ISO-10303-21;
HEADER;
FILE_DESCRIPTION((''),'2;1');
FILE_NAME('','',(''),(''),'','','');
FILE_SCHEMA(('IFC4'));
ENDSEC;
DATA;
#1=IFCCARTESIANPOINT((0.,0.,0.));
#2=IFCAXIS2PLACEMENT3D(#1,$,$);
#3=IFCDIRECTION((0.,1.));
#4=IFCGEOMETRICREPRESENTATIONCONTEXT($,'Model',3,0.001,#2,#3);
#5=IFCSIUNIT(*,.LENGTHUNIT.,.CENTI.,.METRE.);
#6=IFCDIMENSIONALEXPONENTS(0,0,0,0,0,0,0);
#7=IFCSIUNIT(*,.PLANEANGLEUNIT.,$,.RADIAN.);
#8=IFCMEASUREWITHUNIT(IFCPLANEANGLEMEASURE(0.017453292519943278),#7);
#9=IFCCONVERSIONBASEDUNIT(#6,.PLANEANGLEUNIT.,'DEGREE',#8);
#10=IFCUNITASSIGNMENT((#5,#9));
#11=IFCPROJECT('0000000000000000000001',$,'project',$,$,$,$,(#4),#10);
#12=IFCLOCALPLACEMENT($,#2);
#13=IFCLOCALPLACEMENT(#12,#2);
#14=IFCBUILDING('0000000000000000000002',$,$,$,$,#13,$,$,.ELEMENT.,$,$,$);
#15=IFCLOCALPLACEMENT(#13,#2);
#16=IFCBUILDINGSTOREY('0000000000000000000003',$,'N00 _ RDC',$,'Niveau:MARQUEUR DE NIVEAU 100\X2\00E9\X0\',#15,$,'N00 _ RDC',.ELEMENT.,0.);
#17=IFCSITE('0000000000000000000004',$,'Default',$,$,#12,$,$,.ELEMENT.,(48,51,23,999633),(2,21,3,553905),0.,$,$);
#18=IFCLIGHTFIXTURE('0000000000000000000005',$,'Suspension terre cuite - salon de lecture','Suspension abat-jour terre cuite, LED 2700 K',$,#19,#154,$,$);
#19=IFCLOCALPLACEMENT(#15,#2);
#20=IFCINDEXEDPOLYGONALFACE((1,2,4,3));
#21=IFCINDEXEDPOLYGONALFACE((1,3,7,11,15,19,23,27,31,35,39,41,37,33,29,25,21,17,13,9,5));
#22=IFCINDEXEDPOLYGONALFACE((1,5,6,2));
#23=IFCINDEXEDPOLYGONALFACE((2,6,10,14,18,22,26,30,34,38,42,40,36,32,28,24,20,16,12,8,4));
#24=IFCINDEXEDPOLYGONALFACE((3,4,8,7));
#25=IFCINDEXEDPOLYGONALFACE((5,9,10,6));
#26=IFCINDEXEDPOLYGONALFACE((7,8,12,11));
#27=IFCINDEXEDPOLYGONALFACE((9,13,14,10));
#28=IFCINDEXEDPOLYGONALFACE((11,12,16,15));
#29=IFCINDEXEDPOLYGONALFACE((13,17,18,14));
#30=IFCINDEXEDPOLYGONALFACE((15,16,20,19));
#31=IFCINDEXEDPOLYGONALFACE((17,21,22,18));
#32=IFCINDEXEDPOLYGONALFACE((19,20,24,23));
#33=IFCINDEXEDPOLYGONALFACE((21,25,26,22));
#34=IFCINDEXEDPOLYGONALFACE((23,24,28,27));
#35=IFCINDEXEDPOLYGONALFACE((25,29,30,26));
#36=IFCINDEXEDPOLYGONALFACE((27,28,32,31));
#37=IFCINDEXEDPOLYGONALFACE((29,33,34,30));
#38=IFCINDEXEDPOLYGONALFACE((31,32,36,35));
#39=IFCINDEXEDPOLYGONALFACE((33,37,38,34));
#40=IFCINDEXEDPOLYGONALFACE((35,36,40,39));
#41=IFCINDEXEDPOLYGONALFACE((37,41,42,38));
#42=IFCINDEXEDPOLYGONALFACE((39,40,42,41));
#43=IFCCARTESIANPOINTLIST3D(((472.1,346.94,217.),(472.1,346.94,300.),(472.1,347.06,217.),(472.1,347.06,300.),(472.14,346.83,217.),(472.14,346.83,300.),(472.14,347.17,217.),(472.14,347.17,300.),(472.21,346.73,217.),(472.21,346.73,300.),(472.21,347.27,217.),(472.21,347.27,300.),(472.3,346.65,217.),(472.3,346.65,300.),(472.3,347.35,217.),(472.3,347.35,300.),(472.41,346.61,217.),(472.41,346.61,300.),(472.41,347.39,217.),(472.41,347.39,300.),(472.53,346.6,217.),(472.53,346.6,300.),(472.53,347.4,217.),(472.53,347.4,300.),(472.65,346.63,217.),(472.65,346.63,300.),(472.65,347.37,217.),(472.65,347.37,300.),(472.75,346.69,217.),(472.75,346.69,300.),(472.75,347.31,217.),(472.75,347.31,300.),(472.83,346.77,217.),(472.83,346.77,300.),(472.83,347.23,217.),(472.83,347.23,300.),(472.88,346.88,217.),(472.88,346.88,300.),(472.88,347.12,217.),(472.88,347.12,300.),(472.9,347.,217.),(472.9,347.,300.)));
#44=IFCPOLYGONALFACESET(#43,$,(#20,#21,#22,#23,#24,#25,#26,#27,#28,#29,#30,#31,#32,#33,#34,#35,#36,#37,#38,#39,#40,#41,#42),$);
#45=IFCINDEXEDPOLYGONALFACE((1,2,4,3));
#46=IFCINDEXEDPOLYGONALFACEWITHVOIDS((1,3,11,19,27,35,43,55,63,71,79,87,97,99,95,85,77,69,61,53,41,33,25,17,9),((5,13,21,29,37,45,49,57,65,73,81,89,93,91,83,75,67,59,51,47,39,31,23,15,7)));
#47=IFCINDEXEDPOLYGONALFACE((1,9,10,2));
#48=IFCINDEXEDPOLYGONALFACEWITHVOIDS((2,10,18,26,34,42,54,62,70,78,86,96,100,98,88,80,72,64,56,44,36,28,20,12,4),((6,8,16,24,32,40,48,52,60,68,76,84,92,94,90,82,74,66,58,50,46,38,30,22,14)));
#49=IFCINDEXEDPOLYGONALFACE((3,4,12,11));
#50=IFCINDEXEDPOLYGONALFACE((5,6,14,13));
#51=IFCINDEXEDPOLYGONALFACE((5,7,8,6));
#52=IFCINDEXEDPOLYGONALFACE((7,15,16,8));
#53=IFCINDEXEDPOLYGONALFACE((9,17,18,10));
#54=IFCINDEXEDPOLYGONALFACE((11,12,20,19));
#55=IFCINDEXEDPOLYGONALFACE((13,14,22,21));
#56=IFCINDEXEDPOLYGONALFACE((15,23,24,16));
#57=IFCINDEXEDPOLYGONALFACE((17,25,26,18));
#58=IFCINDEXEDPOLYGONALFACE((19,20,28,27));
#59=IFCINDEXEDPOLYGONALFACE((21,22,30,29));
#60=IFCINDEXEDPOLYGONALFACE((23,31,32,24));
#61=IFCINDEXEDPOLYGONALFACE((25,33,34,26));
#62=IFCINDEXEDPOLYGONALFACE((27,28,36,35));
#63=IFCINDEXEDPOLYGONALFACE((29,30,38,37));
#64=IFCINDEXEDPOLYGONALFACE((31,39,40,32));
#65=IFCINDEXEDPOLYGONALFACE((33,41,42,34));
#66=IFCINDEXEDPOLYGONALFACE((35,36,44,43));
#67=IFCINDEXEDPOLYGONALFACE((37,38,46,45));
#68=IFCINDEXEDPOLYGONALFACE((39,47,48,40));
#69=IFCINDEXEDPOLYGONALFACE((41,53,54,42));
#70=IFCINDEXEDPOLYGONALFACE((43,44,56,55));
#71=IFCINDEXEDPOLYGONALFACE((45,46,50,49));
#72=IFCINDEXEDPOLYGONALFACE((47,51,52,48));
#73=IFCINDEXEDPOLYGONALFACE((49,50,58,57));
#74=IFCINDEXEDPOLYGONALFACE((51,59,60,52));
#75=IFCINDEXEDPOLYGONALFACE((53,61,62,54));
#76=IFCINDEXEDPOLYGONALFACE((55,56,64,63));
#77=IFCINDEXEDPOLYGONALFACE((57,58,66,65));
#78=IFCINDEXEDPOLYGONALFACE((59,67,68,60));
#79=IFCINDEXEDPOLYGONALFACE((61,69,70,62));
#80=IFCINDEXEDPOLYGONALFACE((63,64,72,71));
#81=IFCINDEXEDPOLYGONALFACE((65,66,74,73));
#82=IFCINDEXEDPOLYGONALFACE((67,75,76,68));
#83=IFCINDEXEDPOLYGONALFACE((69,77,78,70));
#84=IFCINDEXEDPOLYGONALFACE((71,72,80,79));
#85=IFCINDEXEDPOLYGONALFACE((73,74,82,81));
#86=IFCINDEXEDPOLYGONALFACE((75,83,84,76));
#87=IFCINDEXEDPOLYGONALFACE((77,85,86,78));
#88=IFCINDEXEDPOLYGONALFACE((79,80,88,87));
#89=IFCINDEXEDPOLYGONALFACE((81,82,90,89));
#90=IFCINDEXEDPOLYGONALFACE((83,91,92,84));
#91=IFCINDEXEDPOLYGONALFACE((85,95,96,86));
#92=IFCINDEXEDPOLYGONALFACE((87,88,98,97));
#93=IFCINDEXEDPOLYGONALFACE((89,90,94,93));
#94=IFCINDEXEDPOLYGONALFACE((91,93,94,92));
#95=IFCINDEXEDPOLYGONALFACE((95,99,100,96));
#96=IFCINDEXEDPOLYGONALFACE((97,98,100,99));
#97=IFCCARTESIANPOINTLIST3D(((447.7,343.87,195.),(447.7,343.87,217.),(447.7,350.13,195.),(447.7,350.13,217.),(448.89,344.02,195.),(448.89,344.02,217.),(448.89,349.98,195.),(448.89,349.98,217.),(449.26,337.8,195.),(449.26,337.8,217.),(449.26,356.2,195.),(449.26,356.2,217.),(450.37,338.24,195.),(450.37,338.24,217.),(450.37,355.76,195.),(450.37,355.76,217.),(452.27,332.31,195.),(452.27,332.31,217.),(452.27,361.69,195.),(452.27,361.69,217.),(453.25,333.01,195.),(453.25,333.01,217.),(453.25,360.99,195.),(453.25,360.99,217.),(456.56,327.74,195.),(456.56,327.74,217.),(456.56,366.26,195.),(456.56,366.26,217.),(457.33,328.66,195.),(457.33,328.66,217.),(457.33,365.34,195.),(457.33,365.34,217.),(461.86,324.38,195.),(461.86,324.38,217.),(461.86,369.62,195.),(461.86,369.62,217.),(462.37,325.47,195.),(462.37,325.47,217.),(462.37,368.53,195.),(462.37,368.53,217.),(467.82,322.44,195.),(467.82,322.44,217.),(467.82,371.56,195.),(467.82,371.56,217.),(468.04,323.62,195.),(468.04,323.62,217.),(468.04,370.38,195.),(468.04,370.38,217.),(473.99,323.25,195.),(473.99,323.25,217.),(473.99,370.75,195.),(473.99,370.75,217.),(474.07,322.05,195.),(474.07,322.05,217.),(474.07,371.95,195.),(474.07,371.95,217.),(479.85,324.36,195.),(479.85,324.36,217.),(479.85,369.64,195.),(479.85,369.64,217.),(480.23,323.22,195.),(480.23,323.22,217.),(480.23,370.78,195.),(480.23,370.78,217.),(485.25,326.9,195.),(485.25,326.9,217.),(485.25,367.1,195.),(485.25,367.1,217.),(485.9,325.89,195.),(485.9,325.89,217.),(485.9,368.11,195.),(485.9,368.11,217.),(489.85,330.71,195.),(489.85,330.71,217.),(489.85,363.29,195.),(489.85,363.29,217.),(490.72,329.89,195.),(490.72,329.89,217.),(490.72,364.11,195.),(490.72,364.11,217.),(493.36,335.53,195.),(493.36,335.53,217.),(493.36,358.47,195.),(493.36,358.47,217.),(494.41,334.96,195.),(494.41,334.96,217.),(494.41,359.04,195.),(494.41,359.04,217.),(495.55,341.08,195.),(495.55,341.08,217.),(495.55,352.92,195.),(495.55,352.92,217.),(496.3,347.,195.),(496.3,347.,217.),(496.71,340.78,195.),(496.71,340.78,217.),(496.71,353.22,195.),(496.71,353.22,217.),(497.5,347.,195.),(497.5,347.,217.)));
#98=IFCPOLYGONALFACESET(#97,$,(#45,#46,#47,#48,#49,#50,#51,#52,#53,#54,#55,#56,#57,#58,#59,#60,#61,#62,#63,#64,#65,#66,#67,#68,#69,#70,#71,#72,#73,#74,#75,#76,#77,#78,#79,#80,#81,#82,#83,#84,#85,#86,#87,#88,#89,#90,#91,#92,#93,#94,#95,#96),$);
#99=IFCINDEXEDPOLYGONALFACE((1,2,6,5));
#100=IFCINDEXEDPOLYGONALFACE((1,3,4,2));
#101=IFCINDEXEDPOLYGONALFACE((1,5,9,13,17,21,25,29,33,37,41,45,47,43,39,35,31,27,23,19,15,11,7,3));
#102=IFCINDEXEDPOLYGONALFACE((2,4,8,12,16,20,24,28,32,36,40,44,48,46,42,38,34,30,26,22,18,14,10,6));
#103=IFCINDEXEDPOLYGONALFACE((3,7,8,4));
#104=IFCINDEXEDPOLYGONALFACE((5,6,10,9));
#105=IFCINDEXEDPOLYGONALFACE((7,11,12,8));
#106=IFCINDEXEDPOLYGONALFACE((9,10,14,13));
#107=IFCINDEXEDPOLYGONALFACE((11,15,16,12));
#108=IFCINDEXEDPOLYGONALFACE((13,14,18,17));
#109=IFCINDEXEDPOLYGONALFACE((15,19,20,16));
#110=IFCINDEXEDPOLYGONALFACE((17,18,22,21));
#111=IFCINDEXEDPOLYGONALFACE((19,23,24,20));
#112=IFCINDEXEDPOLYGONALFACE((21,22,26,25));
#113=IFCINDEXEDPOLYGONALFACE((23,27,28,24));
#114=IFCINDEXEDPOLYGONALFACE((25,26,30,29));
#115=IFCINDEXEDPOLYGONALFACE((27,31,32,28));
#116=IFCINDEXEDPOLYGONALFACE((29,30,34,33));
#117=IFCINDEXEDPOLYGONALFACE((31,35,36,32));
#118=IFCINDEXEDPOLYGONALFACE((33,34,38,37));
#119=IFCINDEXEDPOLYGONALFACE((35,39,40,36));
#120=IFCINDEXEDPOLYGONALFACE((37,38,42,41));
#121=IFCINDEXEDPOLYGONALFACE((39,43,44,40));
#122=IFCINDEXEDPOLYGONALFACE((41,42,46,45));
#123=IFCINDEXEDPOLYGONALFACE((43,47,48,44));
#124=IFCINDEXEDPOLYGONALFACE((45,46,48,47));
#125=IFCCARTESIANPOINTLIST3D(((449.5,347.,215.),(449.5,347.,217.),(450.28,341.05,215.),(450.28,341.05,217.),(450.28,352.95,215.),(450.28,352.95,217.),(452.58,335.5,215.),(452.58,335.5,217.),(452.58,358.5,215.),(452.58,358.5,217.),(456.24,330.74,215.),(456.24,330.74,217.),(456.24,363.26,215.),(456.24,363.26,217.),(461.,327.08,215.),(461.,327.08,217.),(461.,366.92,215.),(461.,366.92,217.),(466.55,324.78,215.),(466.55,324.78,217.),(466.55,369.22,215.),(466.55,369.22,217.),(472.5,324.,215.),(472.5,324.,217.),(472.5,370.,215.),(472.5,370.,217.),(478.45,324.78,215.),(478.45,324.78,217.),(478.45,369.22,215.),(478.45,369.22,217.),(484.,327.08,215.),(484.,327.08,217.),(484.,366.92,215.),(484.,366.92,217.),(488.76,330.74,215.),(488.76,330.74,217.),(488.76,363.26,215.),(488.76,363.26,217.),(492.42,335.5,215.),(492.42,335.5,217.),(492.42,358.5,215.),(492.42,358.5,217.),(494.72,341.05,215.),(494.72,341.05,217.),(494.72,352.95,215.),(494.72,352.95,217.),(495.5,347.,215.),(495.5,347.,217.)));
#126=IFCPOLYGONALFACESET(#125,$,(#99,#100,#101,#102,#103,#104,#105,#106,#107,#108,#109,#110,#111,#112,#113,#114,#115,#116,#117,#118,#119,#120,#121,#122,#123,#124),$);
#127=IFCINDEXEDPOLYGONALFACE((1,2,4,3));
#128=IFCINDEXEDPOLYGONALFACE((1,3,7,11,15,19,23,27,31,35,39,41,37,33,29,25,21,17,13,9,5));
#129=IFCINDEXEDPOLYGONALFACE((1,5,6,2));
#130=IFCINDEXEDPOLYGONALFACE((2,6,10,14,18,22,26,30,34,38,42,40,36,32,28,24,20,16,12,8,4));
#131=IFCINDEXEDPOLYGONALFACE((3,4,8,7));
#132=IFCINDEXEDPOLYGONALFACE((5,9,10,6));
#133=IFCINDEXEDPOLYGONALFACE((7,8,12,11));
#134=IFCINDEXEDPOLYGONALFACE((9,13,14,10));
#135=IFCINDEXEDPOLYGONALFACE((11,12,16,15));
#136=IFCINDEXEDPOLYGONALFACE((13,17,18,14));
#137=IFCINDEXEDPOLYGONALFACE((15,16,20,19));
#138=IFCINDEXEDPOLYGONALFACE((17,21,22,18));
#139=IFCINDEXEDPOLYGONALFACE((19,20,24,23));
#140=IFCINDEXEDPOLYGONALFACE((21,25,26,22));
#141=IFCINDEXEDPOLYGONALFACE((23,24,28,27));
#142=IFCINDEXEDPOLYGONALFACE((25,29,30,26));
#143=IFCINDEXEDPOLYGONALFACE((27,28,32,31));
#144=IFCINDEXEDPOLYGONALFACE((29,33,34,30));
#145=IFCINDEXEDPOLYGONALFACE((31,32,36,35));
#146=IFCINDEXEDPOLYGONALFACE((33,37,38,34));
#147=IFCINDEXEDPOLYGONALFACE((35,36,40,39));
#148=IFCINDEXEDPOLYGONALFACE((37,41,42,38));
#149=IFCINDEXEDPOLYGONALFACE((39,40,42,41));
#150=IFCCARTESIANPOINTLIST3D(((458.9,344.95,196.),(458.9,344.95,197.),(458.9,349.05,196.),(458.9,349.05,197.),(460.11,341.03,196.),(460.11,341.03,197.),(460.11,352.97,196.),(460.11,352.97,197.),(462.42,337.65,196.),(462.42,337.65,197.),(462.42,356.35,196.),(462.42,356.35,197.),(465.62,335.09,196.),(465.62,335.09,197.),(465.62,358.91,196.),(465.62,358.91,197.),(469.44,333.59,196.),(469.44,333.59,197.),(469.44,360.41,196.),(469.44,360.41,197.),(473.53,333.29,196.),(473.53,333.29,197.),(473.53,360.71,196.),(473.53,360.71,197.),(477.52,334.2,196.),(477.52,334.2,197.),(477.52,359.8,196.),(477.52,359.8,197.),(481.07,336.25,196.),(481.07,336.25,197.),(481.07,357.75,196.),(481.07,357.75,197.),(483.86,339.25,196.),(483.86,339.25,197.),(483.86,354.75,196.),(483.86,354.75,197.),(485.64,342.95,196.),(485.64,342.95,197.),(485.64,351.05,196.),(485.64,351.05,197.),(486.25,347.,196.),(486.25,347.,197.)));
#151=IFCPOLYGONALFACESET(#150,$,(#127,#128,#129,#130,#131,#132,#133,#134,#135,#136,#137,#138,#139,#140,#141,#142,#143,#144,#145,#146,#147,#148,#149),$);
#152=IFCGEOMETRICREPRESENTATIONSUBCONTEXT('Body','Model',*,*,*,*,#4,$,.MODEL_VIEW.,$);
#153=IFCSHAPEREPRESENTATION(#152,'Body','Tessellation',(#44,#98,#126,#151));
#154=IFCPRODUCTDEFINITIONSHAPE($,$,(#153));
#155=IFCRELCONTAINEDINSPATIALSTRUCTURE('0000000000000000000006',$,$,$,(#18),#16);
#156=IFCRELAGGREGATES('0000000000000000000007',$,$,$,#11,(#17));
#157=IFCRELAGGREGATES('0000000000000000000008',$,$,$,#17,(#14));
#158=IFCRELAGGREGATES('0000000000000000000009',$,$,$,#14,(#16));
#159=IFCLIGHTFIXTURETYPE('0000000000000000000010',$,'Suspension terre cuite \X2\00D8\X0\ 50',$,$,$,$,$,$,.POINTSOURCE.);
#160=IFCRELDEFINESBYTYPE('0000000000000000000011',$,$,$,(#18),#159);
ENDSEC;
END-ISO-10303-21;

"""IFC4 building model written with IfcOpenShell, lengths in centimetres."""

from ifc_helpers import new_model, entity, si_unit, converted_unit, direction, frame, frame_2d, origin, origin_with_axes, place, context, subcontext, project, spatial, circle, hollow_circle, extrude, type_object, element, save


model = new_model("IFC4")

# Units and contexts
model_context = context("Model", 3, precision=0.001, world=origin(), true_north=direction((0.0, 1.0)))
body_context = subcontext(model_context, "Body", "Model", "MODEL_VIEW")
ifc_project = project(units=[si_unit("LENGTHUNIT", "METRE", prefix="CENTI"), converted_unit("PLANEANGLEUNIT", "DEGREE", entity("IfcPlaneAngleMeasure", 0.017453292519943278), si_unit("PLANEANGLEUNIT", "RADIAN"), dimensions=[0, 0, 0, 0, 0, 0, 0])], contexts=[model_context])

# Site, building, storey
site_placement = place(None, origin())
site = spatial("IfcSite", under=ifc_project, at=site_placement, Name="Default", CompositionType="ELEMENT", RefLatitude=(48, 51, 23, 999633), RefLongitude=(2, 21, 3, 553905), RefElevation=0.0)
building_placement = place(site_placement, origin())
building = spatial("IfcBuilding", under=site, at=building_placement, CompositionType="ELEMENT")
storey_placement = place(building_placement, origin())
storey = spatial("IfcBuildingStorey", under=building, at=storey_placement, Name="N00 _ RDC", ObjectType="Niveau:MARQUEUR DE NIVEAU 100é", LongName="N00 _ RDC", CompositionType="ELEMENT", Elevation=0.0)

# Light fixture
light_fixture_type_1 = type_object("IfcLightFixtureType", Name="Suspension terre cuite Ø 50", PredefinedType="POINTSOURCE")
light_fixture_1_placement = place(storey_placement, origin_with_axes())
element("IfcLightFixture", 1, at=light_fixture_1_placement, inside=storey, type_object=light_fixture_type_1, Name="Suspension terre cuite - salon de lecture", Description="Suspension abat-jour terre cuite, LED 2700 K", context=body_context, shape_type="SweptSolid", body=[
    extrude(circle(Radius=0.4, at=frame_2d((472.5, 347.0))), frame((0.0, 0.0, 217.0)), (0.0, 0.0, 1.0), 83.0),
    extrude(hollow_circle(Radius=25.0, WallThickness=1.2, at=frame_2d((472.5, 347.0))), frame((0.0, 0.0, 195.0)), (0.0, 0.0, 1.0), 22.0),
    extrude(circle(Radius=23.0, at=frame_2d((472.5, 347.0))), frame((0.0, 0.0, 215.0)), (0.0, 0.0, 1.0), 2.0),
    extrude(circle(Radius=13.75, at=frame_2d((472.5, 347.0))), frame((0.0, 0.0, 196.0)), (0.0, 0.0, 1.0), 1.0),
])

save(model, "model.ifc")
